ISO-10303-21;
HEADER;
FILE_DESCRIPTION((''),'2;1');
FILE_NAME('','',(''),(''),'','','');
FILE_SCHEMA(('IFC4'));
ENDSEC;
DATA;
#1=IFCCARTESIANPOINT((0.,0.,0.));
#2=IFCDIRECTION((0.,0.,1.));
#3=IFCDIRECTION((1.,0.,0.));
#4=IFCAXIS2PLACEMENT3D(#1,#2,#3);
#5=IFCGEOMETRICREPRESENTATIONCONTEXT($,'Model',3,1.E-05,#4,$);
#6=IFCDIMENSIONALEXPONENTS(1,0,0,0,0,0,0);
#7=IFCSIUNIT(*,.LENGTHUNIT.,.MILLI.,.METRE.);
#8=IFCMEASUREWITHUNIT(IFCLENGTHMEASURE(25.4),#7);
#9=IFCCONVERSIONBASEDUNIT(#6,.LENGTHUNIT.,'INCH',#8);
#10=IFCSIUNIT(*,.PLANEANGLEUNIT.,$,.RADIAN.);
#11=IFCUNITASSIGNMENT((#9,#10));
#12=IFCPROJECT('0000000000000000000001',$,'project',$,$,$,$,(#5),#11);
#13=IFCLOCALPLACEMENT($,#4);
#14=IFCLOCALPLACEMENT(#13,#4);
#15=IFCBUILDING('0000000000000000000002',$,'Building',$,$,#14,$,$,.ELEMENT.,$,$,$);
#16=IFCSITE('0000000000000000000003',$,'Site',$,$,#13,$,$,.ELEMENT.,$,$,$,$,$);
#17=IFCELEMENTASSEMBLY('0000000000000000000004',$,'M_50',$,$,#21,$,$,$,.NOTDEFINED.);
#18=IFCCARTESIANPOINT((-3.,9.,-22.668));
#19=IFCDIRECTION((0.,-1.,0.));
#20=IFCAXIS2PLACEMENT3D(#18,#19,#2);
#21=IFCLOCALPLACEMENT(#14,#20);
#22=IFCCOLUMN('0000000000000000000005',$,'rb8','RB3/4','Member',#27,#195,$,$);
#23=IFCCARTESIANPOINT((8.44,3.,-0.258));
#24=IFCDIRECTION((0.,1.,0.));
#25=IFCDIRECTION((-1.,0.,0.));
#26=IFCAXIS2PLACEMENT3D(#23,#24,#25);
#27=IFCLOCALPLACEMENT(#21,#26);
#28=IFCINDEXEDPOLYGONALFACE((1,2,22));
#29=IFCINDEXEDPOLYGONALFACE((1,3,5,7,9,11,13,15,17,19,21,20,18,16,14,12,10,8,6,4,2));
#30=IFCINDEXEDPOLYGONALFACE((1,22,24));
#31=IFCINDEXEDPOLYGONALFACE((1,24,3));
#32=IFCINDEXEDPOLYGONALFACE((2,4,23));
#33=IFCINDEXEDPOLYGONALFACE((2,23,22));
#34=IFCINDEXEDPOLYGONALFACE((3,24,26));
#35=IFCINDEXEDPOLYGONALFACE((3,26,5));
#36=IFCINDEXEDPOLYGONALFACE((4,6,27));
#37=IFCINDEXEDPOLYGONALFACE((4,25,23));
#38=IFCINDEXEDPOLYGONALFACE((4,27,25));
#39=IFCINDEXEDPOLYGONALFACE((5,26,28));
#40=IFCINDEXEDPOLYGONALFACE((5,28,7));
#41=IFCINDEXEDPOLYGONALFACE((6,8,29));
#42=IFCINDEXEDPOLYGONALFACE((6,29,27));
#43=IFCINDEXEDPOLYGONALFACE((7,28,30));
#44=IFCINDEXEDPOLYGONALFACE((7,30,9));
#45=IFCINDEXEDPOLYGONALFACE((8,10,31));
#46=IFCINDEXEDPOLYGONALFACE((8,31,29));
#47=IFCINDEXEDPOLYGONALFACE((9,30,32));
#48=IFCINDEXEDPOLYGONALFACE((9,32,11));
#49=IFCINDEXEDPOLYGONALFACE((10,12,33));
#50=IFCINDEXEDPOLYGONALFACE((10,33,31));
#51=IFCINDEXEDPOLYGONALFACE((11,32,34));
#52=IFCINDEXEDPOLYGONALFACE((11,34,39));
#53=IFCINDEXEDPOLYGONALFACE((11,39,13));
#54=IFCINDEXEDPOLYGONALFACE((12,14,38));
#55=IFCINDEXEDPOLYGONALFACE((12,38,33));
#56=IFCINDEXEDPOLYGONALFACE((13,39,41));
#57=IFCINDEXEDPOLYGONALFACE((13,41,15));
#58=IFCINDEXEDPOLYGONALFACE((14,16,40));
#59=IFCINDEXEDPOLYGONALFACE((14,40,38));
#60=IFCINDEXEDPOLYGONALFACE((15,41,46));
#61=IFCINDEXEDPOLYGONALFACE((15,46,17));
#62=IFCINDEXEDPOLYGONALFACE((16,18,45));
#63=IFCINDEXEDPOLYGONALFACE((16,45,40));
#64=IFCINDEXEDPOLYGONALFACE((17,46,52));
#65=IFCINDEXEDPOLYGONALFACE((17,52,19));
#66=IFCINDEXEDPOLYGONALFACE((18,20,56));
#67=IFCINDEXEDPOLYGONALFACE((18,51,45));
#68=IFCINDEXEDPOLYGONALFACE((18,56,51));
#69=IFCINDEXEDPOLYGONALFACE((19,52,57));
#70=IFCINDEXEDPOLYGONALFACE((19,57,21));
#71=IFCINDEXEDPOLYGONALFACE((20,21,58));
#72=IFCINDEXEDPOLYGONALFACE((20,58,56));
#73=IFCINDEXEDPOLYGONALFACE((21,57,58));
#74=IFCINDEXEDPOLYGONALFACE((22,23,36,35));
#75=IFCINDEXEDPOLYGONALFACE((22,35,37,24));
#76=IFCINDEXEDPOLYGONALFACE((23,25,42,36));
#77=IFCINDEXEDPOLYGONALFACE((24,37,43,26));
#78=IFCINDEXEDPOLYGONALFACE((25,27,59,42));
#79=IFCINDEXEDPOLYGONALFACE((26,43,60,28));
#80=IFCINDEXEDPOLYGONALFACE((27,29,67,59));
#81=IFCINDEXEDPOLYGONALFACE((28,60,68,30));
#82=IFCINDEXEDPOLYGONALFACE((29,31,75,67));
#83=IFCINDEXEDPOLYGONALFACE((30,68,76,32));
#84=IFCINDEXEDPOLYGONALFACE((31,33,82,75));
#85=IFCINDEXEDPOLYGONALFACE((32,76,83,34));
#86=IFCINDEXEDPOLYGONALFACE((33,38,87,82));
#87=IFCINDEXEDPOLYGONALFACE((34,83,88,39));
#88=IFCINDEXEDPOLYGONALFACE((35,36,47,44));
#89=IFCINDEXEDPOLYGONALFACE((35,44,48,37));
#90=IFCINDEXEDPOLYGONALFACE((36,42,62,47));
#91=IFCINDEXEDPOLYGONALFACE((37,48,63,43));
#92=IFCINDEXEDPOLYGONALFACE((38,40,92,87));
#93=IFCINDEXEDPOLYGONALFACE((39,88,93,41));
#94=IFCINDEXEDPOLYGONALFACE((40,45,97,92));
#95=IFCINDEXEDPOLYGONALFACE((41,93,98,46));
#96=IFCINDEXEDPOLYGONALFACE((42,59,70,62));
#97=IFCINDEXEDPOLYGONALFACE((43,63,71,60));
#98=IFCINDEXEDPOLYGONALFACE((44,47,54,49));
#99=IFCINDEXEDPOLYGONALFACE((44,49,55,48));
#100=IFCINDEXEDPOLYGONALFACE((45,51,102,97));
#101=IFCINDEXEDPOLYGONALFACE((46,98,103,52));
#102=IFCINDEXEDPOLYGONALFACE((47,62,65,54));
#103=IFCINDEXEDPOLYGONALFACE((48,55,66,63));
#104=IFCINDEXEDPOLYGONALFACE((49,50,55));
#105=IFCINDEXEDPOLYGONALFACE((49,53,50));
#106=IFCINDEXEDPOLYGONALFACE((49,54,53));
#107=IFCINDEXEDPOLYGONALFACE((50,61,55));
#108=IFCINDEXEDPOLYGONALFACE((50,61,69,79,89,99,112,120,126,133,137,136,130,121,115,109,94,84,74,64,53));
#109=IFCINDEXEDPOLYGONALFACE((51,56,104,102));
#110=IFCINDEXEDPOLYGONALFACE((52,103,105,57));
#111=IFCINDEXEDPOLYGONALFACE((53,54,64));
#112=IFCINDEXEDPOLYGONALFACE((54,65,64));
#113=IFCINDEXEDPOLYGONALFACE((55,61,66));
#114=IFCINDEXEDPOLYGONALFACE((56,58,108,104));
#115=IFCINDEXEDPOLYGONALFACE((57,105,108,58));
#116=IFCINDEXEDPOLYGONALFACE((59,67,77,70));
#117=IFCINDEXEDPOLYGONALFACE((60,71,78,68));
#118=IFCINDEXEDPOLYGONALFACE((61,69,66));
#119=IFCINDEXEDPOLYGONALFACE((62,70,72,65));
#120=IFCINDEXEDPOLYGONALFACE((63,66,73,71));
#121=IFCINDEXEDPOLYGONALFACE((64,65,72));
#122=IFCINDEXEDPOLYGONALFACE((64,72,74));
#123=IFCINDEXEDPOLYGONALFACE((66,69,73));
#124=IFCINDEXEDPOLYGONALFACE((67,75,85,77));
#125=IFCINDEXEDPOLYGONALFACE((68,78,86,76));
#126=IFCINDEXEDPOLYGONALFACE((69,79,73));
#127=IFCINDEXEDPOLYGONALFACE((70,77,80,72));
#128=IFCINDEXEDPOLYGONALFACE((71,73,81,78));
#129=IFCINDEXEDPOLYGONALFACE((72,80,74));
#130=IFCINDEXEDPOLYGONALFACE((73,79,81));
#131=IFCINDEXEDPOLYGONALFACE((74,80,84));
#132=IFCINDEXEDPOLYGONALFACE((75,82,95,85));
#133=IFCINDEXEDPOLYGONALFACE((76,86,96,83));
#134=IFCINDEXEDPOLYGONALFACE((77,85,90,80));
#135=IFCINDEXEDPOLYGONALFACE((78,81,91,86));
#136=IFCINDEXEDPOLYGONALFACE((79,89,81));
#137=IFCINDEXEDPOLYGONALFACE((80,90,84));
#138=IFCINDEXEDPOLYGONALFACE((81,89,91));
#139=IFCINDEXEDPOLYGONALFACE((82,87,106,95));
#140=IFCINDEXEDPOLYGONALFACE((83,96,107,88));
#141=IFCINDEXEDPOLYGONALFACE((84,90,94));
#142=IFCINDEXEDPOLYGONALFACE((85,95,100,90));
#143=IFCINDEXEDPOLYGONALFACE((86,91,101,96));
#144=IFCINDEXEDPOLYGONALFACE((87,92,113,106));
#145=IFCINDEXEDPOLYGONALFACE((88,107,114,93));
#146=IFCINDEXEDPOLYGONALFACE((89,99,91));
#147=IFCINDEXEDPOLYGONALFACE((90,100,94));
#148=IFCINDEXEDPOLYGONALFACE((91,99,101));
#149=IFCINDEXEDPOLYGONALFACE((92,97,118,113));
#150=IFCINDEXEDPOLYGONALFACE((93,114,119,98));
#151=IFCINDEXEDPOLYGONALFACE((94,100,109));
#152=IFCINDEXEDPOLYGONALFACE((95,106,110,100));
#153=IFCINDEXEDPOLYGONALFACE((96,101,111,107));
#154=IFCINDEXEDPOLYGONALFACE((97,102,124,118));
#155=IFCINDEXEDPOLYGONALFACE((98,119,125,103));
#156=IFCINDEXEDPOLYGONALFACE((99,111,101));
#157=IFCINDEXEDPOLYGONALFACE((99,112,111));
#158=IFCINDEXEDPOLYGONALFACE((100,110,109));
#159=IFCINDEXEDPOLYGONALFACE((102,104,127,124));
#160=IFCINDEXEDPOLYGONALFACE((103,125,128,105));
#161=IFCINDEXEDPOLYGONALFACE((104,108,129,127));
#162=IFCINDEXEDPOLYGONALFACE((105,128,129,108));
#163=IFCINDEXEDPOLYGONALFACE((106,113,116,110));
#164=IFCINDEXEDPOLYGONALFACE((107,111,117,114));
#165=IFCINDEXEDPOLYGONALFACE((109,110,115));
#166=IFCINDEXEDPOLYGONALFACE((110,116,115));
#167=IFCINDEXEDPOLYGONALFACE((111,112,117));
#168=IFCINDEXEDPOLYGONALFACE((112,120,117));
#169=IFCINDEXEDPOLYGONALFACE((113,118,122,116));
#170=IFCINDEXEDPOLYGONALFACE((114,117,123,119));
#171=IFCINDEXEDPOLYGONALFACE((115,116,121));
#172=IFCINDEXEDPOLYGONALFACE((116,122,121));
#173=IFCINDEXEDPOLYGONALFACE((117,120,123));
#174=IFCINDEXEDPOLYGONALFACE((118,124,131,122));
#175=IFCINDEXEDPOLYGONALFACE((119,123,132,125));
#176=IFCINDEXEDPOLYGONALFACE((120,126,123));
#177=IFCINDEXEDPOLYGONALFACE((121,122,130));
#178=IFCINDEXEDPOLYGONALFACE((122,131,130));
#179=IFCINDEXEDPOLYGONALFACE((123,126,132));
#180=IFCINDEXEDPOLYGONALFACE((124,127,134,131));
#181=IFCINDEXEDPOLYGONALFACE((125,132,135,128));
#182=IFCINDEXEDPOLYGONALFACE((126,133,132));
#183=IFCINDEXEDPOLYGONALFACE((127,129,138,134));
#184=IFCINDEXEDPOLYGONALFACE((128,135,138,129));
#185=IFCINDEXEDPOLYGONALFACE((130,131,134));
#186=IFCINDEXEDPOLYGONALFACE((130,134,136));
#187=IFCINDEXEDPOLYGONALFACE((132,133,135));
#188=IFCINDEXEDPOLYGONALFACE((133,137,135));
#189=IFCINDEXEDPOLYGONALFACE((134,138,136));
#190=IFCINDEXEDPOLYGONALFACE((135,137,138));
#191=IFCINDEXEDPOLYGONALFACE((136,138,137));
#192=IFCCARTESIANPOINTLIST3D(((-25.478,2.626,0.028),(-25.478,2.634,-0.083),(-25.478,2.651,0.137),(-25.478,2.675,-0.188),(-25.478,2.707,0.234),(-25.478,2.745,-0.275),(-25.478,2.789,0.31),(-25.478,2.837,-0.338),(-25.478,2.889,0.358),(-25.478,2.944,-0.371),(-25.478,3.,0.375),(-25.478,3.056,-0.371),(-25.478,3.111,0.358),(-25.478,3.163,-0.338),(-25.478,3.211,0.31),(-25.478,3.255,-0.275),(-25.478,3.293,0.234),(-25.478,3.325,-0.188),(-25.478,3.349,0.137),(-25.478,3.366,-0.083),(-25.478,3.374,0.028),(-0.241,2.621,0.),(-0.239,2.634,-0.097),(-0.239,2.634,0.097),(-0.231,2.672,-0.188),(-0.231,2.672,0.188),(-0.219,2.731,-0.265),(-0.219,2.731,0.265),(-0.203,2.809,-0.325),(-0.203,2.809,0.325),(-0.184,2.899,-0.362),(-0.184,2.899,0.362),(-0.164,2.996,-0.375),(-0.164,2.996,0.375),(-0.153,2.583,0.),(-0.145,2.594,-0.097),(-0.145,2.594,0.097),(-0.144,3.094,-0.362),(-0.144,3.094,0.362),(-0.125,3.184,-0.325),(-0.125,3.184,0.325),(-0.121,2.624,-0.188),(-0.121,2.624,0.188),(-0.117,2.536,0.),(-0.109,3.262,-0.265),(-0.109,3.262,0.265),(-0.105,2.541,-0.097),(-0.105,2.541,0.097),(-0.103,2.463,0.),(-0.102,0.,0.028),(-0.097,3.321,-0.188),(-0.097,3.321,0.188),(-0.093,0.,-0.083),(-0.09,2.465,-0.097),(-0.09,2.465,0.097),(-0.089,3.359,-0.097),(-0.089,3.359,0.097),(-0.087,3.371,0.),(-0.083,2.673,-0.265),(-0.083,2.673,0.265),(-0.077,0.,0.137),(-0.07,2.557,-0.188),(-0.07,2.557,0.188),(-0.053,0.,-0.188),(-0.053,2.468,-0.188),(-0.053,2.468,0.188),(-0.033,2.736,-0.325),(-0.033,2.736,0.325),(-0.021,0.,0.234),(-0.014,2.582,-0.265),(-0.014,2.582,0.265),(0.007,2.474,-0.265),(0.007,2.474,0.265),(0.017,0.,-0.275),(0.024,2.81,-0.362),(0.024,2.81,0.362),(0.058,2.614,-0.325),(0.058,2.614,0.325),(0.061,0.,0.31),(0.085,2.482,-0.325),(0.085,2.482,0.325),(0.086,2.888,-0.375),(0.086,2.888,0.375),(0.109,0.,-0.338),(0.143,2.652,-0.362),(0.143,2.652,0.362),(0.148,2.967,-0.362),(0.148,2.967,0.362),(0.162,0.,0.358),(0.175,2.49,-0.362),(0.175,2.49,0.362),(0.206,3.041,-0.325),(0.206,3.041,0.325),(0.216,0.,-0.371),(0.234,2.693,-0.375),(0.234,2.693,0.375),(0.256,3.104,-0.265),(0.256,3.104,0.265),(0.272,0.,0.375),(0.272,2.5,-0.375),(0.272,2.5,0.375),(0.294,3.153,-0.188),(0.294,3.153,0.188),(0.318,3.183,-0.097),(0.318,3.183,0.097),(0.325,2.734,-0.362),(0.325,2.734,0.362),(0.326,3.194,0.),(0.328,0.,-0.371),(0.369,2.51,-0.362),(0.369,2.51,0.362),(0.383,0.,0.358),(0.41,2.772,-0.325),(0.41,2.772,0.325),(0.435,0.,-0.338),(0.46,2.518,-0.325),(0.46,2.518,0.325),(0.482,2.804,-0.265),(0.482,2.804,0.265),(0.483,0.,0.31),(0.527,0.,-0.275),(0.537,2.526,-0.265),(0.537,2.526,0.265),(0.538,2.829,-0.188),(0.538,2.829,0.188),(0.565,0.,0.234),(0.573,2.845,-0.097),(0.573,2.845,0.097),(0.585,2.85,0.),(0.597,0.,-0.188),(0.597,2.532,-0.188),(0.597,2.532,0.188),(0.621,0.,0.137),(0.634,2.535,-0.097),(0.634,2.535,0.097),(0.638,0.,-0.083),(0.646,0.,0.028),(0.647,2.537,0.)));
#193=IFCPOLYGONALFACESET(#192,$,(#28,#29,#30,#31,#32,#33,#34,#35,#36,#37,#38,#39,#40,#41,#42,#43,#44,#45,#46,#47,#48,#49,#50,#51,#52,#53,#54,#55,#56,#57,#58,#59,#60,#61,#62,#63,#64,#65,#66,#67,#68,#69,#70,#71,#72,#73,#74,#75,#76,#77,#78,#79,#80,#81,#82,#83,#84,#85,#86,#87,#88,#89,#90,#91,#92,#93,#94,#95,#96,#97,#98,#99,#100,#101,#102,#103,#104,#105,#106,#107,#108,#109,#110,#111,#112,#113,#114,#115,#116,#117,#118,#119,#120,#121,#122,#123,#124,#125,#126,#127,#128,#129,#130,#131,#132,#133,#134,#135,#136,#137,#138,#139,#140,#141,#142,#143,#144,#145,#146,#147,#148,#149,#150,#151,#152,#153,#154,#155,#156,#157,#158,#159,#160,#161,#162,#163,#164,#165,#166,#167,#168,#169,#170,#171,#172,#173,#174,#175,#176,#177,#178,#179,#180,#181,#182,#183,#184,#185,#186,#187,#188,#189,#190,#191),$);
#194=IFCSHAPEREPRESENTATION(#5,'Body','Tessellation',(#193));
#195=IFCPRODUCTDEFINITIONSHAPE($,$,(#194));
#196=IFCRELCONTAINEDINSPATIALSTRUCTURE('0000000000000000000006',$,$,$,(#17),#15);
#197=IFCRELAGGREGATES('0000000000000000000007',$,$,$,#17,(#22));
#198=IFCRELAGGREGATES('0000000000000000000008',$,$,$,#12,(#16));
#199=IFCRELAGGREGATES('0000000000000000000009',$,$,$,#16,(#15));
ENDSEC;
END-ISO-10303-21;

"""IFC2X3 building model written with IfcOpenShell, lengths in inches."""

from ifc_helpers import new_model, entity, si_unit, converted_unit, frame, origin_with_axes, place, context, project, spatial, element, aggregate, save


model = new_model("IFC2X3")

# Units and contexts
model_context = context("Model", 3, precision=1e-05, world=origin_with_axes())
ifc_project = project(units=[converted_unit("LENGTHUNIT", "INCH", entity("IfcLengthMeasure", 25.4), si_unit("LENGTHUNIT", "METRE", prefix="MILLI"), dimensions=[1, 0, 0, 0, 0, 0, 0]), si_unit("PLANEANGLEUNIT", "RADIAN")], contexts=[model_context])

# Site, building
site_placement = place(None, origin_with_axes())
site = spatial("IfcSite", under=ifc_project, at=site_placement, Name="Site", CompositionType="ELEMENT")
building_placement = place(site_placement, origin_with_axes())
building = spatial("IfcBuilding", under=site, at=building_placement, Name="Building", CompositionType="ELEMENT")

# Element assembly, column
assembly_1_placement = place(building_placement, frame((-3.0, 9.0, -22.668), z_axis=(0.0, -1.0, 0.0), x_axis=(0.0, 0.0, 1.0)))
assembly_1 = element("IfcElementAssembly", 1, at=assembly_1_placement, inside=building, Name="M_50", PredefinedType="NOTDEFINED")
column_1_placement = place(assembly_1_placement, frame((8.44, 3.0, -0.258), z_axis=(0.0, 1.0, 0.0), x_axis=(-1.0, 0.0, 0.0)))
cartesian_point_1 = entity("IfcCartesianPoint", [0.0, 0.0, 0.0])
ifc_direction_1 = entity("IfcDirection", [0.0, 0.0, 1.0])
ifc_direction_2 = entity("IfcDirection", [1.0, 0.0, 0.0])
column_1 = element("IfcColumn", 2, at=column_1_placement, Name="rb8", Description="RB3/4", ObjectType="Member", context=model_context, shape_type="SweptSolid", body=[
    entity("IfcSurfaceCurveSweptAreaSolid", entity("IfcCircleProfileDef", "AREA", None, entity("IfcAxis2Placement2D", entity("IfcCartesianPoint", [0.0, 0.0]), entity("IfcDirection", [1.0, 0.0])), 0.375), entity("IfcAxis2Placement3D", cartesian_point_1, ifc_direction_1, ifc_direction_2), entity("IfcPolyline", [entity("IfcCartesianPoint", [0.272, 0.0]), entity("IfcCartesianPoint", [0.272, 2.5]), entity("IfcCartesianPoint", [0.234, 2.693]), entity("IfcCartesianPoint", [0.086, 2.888]), entity("IfcCartesianPoint", [-0.164, 2.996]), entity("IfcCartesianPoint", [-25.478, 3.0])]), 0.0, 1.0, entity("IfcPlane", entity("IfcAxis2Placement3D", cartesian_point_1, ifc_direction_1, ifc_direction_2))),
])
aggregate(assembly_1, [column_1])

save(model, "model.ifc")
